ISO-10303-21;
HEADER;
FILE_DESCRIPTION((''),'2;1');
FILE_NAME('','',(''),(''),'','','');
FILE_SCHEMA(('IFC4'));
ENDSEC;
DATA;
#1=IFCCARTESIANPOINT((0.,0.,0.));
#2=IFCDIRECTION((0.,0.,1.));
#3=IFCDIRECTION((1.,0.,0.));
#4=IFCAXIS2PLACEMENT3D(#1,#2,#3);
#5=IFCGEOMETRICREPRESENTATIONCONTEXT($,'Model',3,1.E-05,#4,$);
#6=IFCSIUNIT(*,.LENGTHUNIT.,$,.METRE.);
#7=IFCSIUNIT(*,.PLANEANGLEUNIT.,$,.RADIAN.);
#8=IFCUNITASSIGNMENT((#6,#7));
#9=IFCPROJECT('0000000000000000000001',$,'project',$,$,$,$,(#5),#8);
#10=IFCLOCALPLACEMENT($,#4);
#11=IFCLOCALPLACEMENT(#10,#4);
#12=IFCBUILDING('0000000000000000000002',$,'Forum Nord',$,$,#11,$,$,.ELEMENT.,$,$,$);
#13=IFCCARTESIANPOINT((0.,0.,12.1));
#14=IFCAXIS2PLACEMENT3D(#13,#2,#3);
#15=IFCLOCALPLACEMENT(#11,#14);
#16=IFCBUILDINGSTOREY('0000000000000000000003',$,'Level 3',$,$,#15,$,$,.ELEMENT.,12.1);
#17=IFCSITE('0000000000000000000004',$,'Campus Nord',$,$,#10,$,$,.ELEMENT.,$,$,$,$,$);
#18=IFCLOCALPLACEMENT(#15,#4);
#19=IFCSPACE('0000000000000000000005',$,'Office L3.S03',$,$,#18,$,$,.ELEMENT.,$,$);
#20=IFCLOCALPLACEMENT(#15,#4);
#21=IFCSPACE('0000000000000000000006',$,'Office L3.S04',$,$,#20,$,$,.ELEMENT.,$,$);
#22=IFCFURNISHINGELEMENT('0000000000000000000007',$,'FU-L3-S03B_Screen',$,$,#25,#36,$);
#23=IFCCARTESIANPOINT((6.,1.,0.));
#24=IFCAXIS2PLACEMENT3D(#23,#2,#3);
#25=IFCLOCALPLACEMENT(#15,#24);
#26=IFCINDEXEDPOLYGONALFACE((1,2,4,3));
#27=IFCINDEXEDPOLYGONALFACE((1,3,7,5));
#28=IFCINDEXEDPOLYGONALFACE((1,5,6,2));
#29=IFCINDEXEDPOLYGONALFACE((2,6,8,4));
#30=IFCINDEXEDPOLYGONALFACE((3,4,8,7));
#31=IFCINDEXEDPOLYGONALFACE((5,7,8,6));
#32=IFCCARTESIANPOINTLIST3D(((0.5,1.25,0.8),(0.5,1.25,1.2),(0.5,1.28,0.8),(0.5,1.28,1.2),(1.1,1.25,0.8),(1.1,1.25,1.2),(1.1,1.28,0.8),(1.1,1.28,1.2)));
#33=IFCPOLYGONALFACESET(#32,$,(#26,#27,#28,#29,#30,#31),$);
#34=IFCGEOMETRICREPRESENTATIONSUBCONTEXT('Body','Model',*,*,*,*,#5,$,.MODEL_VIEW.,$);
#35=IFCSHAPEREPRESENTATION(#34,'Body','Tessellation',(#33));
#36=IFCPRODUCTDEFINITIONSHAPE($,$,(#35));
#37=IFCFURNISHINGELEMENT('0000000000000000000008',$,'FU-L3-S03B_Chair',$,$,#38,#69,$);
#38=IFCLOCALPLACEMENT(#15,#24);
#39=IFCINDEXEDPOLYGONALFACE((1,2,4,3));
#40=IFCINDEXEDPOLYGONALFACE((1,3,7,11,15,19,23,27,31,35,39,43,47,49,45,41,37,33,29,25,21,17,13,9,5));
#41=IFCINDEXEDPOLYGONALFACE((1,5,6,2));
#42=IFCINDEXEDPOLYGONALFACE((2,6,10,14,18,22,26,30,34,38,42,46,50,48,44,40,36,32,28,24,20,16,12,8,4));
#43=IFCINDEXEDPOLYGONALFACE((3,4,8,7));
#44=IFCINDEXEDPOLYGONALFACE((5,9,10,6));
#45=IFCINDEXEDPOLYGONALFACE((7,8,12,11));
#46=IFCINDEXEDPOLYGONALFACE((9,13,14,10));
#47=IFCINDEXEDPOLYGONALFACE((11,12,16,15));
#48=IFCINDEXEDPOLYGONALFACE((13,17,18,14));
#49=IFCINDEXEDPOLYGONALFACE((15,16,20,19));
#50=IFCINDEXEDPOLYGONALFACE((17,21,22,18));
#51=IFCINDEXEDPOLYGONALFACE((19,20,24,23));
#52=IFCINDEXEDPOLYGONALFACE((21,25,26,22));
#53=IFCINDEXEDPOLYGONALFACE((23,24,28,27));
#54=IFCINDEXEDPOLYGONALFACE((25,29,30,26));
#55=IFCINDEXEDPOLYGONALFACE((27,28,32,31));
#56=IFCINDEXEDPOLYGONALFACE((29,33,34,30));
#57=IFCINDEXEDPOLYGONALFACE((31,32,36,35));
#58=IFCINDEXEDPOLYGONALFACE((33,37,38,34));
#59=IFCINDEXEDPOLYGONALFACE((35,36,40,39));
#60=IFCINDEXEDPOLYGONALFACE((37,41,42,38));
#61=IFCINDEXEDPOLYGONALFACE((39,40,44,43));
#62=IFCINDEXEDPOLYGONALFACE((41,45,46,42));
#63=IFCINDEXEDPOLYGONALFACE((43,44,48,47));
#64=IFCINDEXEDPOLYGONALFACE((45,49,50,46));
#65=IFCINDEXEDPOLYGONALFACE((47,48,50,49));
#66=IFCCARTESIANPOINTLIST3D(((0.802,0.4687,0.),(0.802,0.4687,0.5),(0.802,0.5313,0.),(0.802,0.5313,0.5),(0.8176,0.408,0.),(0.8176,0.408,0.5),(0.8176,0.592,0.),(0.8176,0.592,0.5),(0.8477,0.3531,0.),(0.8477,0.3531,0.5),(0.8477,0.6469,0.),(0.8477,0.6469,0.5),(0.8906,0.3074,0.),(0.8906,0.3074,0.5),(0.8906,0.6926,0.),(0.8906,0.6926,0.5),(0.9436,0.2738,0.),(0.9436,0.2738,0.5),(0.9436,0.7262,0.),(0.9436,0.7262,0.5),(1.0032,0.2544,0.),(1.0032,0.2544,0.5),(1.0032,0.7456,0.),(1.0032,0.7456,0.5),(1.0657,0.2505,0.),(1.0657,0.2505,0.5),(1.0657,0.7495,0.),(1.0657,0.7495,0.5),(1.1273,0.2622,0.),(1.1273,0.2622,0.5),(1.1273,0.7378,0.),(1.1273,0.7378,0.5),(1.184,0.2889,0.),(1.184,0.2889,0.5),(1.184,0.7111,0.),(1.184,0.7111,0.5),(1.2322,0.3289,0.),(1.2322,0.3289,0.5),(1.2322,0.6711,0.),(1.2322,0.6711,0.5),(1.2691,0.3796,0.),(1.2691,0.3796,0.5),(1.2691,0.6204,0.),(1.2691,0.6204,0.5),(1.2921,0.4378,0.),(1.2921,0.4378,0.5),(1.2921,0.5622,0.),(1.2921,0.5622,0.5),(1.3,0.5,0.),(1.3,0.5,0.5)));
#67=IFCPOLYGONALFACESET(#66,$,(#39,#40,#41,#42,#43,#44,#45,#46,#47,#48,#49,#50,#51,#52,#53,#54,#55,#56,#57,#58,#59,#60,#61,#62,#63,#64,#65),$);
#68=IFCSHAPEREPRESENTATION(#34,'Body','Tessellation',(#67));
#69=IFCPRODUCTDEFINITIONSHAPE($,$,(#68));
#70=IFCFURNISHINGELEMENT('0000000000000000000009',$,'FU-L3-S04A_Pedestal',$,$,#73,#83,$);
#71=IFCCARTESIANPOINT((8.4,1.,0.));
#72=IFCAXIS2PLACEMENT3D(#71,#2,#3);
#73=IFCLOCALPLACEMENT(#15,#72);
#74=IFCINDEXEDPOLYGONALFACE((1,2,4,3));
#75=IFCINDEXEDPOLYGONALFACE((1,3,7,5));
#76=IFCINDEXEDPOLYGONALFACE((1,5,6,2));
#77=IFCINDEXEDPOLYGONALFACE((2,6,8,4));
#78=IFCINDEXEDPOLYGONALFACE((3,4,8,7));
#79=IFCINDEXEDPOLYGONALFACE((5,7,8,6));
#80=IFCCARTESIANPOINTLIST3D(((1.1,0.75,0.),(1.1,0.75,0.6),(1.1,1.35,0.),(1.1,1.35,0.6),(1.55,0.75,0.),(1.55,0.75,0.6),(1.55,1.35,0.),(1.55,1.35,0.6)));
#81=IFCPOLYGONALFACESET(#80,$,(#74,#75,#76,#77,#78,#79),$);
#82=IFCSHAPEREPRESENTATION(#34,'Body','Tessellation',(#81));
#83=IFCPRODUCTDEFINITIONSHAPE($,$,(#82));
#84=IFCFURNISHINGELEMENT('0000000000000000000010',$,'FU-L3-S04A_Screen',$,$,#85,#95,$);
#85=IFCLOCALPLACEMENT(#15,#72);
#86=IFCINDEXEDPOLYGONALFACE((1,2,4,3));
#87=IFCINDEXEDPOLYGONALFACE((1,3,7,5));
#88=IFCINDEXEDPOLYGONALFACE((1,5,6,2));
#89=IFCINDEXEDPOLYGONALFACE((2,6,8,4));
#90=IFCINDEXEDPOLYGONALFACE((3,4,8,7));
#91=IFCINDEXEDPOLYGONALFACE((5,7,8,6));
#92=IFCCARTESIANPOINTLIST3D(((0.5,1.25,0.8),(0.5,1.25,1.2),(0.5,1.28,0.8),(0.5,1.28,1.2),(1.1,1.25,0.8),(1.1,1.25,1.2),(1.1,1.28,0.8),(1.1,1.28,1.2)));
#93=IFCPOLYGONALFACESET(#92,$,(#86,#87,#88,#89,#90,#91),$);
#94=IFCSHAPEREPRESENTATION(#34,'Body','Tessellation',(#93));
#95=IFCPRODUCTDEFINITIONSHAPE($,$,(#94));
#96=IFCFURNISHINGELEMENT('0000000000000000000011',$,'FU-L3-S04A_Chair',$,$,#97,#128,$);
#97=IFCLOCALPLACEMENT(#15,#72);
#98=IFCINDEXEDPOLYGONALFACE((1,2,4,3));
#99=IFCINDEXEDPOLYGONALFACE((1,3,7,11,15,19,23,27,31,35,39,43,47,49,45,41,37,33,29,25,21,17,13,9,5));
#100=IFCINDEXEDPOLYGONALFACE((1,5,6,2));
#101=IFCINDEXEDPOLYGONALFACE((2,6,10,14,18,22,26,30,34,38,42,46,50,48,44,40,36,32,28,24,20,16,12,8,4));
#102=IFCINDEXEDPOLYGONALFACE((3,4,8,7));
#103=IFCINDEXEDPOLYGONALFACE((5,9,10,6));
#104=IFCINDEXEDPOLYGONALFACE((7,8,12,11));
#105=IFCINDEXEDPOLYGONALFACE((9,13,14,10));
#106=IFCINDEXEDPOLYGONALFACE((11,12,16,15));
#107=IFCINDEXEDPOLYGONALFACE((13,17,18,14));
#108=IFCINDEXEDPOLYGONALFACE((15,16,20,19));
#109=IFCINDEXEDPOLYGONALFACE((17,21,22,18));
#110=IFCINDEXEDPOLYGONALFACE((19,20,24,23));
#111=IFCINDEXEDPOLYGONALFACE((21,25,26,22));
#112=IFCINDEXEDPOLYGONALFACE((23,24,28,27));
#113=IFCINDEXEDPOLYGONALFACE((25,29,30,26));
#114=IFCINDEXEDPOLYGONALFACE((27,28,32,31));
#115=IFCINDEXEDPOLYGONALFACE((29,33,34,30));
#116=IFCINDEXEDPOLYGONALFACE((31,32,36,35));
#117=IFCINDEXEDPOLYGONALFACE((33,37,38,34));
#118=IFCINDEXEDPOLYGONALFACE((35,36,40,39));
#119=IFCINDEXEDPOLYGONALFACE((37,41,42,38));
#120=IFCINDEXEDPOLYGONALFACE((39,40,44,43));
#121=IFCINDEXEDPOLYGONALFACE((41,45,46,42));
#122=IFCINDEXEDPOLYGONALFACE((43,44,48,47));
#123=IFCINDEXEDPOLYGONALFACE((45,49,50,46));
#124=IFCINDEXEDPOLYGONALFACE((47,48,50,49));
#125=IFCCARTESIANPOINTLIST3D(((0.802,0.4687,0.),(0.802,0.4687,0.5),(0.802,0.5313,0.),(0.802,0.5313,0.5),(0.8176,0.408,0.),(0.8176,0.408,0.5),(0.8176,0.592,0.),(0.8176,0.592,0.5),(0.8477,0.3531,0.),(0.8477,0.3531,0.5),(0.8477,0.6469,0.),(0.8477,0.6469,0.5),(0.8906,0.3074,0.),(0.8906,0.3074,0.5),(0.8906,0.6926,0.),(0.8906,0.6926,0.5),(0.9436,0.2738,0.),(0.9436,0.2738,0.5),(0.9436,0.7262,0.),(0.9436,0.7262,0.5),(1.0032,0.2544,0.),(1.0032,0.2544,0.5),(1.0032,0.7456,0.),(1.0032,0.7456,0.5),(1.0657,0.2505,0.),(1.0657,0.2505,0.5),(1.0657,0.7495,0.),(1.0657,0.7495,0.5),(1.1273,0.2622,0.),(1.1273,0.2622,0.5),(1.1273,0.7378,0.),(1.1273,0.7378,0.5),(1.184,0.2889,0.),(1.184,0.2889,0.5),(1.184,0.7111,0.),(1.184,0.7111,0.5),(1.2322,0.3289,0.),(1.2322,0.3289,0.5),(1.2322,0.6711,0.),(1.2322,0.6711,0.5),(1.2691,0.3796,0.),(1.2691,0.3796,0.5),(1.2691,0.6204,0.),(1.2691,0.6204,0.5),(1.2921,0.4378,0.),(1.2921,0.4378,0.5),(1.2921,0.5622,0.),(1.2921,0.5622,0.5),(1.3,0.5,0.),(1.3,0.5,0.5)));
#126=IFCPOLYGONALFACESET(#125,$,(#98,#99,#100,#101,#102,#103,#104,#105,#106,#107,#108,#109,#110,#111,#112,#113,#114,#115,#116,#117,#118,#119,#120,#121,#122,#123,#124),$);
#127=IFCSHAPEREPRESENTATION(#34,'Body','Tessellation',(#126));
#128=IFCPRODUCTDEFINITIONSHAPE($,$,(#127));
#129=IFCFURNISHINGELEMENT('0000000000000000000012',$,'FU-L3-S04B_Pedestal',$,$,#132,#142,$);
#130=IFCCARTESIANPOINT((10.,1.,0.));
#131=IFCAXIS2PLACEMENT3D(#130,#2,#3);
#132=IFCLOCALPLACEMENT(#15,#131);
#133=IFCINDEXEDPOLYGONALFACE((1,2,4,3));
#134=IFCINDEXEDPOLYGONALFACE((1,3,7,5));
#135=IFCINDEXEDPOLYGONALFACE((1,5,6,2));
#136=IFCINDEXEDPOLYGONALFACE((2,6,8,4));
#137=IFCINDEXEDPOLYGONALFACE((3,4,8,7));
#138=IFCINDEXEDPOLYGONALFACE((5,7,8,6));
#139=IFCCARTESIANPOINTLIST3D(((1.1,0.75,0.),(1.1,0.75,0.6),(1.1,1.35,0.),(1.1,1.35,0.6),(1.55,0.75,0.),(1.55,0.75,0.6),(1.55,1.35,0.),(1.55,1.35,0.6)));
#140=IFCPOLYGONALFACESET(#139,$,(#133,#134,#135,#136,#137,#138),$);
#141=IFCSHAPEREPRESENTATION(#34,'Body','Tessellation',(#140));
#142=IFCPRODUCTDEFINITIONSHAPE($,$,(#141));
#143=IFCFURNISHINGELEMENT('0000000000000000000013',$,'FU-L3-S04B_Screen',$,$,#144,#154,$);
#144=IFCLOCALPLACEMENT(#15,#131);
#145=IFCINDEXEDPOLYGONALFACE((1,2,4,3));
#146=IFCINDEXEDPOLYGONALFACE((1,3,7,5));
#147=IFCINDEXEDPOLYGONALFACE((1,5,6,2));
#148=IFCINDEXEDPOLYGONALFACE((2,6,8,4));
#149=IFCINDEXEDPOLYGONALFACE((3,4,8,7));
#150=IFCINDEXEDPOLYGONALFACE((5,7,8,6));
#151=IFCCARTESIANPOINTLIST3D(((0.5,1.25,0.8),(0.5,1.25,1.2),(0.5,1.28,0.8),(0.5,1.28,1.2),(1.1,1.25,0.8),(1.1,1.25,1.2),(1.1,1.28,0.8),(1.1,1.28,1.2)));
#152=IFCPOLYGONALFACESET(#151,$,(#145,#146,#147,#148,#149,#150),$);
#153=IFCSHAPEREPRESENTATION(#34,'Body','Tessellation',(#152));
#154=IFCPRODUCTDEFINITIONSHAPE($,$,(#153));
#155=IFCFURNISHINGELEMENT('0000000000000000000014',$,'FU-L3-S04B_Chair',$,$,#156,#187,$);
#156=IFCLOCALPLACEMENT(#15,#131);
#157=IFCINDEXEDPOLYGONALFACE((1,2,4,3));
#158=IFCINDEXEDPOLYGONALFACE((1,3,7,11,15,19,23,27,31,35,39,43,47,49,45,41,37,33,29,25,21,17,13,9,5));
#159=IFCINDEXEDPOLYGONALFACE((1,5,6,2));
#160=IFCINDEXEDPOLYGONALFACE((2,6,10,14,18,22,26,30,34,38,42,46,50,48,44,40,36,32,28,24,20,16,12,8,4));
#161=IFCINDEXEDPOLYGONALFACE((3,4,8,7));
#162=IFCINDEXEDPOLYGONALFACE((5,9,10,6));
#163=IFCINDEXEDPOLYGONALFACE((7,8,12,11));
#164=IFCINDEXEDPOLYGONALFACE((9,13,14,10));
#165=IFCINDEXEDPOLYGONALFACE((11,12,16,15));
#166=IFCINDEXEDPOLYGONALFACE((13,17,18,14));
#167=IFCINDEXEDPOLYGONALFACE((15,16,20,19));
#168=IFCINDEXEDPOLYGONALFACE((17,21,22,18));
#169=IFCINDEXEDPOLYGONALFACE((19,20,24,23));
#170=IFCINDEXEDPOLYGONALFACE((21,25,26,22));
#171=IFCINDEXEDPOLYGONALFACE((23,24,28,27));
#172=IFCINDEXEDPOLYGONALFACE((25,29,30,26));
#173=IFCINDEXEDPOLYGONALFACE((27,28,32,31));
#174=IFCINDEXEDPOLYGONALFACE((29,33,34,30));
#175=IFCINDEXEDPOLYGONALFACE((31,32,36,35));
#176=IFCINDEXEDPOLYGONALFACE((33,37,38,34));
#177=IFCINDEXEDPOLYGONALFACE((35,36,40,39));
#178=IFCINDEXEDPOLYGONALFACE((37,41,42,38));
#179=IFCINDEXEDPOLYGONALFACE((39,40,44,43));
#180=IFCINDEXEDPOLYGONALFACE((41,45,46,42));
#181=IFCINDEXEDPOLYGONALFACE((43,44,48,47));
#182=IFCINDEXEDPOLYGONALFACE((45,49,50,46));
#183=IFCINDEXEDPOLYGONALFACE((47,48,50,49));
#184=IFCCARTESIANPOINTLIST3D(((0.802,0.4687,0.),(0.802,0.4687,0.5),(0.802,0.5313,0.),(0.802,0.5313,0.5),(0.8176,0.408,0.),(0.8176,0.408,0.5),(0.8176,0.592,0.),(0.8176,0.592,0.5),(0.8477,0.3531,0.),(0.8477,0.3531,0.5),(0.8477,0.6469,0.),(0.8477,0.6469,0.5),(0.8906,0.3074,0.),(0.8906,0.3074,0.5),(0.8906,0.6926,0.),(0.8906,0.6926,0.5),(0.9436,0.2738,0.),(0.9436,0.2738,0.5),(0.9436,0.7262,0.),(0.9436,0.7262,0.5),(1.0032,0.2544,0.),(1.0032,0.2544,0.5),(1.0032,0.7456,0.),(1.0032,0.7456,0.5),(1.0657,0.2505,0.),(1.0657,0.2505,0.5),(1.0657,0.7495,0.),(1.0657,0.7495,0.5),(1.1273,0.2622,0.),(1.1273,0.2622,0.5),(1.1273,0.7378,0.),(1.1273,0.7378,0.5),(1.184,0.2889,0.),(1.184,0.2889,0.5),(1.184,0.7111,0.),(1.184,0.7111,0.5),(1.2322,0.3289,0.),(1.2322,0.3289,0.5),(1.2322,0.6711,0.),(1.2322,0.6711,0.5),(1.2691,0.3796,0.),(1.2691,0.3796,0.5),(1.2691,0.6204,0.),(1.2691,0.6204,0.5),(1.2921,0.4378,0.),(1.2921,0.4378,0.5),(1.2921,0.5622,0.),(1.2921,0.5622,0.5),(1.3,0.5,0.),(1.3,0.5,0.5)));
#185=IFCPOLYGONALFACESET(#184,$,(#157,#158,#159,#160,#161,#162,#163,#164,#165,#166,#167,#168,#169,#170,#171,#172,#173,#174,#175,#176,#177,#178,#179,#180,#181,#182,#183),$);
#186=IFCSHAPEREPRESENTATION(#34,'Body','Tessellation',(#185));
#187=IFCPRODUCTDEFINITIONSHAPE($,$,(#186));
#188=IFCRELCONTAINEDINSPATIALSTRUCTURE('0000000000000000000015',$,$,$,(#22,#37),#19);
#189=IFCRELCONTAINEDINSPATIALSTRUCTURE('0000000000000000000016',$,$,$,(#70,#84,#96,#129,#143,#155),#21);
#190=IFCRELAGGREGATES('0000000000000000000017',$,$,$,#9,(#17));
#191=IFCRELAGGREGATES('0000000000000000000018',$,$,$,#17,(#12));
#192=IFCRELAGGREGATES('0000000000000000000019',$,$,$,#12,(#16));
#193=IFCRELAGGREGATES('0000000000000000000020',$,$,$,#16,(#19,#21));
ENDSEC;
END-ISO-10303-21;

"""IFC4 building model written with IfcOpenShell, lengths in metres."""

from ifc_helpers import new_model, si_unit, frame, frame_2d, origin_with_axes, place, context, subcontext, project, spatial, rectangle, circle, extrude, element, save


model = new_model("IFC4")

# Units and contexts
model_context = context("Model", 3, precision=1e-05, world=origin_with_axes())
body_context = subcontext(model_context, "Body", "Model", "MODEL_VIEW")
ifc_project = project(units=[si_unit("LENGTHUNIT", "METRE"), si_unit("PLANEANGLEUNIT", "RADIAN")], contexts=[model_context])

# Site, building, storey
site_placement = place(None, origin_with_axes())
site = spatial("IfcSite", under=ifc_project, at=site_placement, Name="Campus Nord", CompositionType="ELEMENT")
building_placement = place(site_placement, origin_with_axes())
building = spatial("IfcBuilding", under=site, at=building_placement, Name="Forum Nord", CompositionType="ELEMENT")
storey_placement = place(building_placement, frame((0.0, 0.0, 12.1), z_axis=(0.0, 0.0, 1.0), x_axis=(1.0, 0.0, 0.0)))
storey = spatial("IfcBuildingStorey", under=building, at=storey_placement, Name="Level 3", CompositionType="ELEMENT", Elevation=12.1)

# Shared definitions
space_1_placement = place(storey_placement, origin_with_axes())
space_1 = spatial("IfcSpace", under=storey, at=space_1_placement, Name="Office L3.S03", CompositionType="ELEMENT")

# Furnishing elements
furnishing_1_placement = place(storey_placement, frame((6.0, 1.0, 0.0), z_axis=(0.0, 0.0, 1.0), x_axis=(1.0, 0.0, 0.0)))
element("IfcFurnishingElement", 1, at=furnishing_1_placement, inside=space_1, Name="FU-L3-S03B_Screen", context=body_context, shape_type="SweptSolid", body=[
    extrude(rectangle(XDim=0.6, YDim=0.03, at=frame_2d((0.8, 1.265), x_axis=(1.0, 0.0))), frame((0.0, 0.0, 0.8), z_axis=(0.0, 0.0, 1.0), x_axis=(1.0, 0.0, 0.0)), (0.0, 0.0, 1.0), 0.4),
])
furnishing_2_placement = place(storey_placement, frame((6.0, 1.0, 0.0), z_axis=(0.0, 0.0, 1.0), x_axis=(1.0, 0.0, 0.0)))
element("IfcFurnishingElement", 2, at=furnishing_2_placement, inside=space_1, Name="FU-L3-S03B_Chair", context=body_context, shape_type="SweptSolid", body=[
    extrude(circle(Radius=0.25, at=frame_2d((1.05, 0.5), x_axis=(1.0, 0.0))), origin_with_axes(), (0.0, 0.0, 1.0), 0.5),
])

# Shared definitions
space_2_placement = place(storey_placement, origin_with_axes())
space_2 = spatial("IfcSpace", under=storey, at=space_2_placement, Name="Office L3.S04", CompositionType="ELEMENT")

# Furnishing elements
furnishing_3_placement = place(storey_placement, frame((8.4, 1.0, 0.0), z_axis=(0.0, 0.0, 1.0), x_axis=(1.0, 0.0, 0.0)))
element("IfcFurnishingElement", 3, at=furnishing_3_placement, inside=space_2, Name="FU-L3-S04A_Pedestal", context=body_context, shape_type="SweptSolid", body=[
    extrude(rectangle(XDim=0.45, YDim=0.6, at=frame_2d((1.325, 1.05), x_axis=(1.0, 0.0))), origin_with_axes(), (0.0, 0.0, 1.0), 0.6),
])
furnishing_4_placement = place(storey_placement, frame((8.4, 1.0, 0.0), z_axis=(0.0, 0.0, 1.0), x_axis=(1.0, 0.0, 0.0)))
element("IfcFurnishingElement", 4, at=furnishing_4_placement, inside=space_2, Name="FU-L3-S04A_Screen", context=body_context, shape_type="SweptSolid", body=[
    extrude(rectangle(XDim=0.6, YDim=0.03, at=frame_2d((0.8, 1.265), x_axis=(1.0, 0.0))), frame((0.0, 0.0, 0.8), z_axis=(0.0, 0.0, 1.0), x_axis=(1.0, 0.0, 0.0)), (0.0, 0.0, 1.0), 0.4),
])
furnishing_5_placement = place(storey_placement, frame((8.4, 1.0, 0.0), z_axis=(0.0, 0.0, 1.0), x_axis=(1.0, 0.0, 0.0)))
element("IfcFurnishingElement", 5, at=furnishing_5_placement, inside=space_2, Name="FU-L3-S04A_Chair", context=body_context, shape_type="SweptSolid", body=[
    extrude(circle(Radius=0.25, at=frame_2d((1.05, 0.5), x_axis=(1.0, 0.0))), origin_with_axes(), (0.0, 0.0, 1.0), 0.5),
])
furnishing_6_placement = place(storey_placement, frame((10.0, 1.0, 0.0), z_axis=(0.0, 0.0, 1.0), x_axis=(1.0, 0.0, 0.0)))
element("IfcFurnishingElement", 6, at=furnishing_6_placement, inside=space_2, Name="FU-L3-S04B_Pedestal", context=body_context, shape_type="SweptSolid", body=[
    extrude(rectangle(XDim=0.45, YDim=0.6, at=frame_2d((1.325, 1.05), x_axis=(1.0, 0.0))), origin_with_axes(), (0.0, 0.0, 1.0), 0.6),
])
furnishing_7_placement = place(storey_placement, frame((10.0, 1.0, 0.0), z_axis=(0.0, 0.0, 1.0), x_axis=(1.0, 0.0, 0.0)))
element("IfcFurnishingElement", 7, at=furnishing_7_placement, inside=space_2, Name="FU-L3-S04B_Screen", context=body_context, shape_type="SweptSolid", body=[
    extrude(rectangle(XDim=0.6, YDim=0.03, at=frame_2d((0.8, 1.265), x_axis=(1.0, 0.0))), frame((0.0, 0.0, 0.8), z_axis=(0.0, 0.0, 1.0), x_axis=(1.0, 0.0, 0.0)), (0.0, 0.0, 1.0), 0.4),
])
furnishing_8_placement = place(storey_placement, frame((10.0, 1.0, 0.0), z_axis=(0.0, 0.0, 1.0), x_axis=(1.0, 0.0, 0.0)))
element("IfcFurnishingElement", 8, at=furnishing_8_placement, inside=space_2, Name="FU-L3-S04B_Chair", context=body_context, shape_type="SweptSolid", body=[
    extrude(circle(Radius=0.25, at=frame_2d((1.05, 0.5), x_axis=(1.0, 0.0))), origin_with_axes(), (0.0, 0.0, 1.0), 0.5),
])

save(model, "model.ifc")
